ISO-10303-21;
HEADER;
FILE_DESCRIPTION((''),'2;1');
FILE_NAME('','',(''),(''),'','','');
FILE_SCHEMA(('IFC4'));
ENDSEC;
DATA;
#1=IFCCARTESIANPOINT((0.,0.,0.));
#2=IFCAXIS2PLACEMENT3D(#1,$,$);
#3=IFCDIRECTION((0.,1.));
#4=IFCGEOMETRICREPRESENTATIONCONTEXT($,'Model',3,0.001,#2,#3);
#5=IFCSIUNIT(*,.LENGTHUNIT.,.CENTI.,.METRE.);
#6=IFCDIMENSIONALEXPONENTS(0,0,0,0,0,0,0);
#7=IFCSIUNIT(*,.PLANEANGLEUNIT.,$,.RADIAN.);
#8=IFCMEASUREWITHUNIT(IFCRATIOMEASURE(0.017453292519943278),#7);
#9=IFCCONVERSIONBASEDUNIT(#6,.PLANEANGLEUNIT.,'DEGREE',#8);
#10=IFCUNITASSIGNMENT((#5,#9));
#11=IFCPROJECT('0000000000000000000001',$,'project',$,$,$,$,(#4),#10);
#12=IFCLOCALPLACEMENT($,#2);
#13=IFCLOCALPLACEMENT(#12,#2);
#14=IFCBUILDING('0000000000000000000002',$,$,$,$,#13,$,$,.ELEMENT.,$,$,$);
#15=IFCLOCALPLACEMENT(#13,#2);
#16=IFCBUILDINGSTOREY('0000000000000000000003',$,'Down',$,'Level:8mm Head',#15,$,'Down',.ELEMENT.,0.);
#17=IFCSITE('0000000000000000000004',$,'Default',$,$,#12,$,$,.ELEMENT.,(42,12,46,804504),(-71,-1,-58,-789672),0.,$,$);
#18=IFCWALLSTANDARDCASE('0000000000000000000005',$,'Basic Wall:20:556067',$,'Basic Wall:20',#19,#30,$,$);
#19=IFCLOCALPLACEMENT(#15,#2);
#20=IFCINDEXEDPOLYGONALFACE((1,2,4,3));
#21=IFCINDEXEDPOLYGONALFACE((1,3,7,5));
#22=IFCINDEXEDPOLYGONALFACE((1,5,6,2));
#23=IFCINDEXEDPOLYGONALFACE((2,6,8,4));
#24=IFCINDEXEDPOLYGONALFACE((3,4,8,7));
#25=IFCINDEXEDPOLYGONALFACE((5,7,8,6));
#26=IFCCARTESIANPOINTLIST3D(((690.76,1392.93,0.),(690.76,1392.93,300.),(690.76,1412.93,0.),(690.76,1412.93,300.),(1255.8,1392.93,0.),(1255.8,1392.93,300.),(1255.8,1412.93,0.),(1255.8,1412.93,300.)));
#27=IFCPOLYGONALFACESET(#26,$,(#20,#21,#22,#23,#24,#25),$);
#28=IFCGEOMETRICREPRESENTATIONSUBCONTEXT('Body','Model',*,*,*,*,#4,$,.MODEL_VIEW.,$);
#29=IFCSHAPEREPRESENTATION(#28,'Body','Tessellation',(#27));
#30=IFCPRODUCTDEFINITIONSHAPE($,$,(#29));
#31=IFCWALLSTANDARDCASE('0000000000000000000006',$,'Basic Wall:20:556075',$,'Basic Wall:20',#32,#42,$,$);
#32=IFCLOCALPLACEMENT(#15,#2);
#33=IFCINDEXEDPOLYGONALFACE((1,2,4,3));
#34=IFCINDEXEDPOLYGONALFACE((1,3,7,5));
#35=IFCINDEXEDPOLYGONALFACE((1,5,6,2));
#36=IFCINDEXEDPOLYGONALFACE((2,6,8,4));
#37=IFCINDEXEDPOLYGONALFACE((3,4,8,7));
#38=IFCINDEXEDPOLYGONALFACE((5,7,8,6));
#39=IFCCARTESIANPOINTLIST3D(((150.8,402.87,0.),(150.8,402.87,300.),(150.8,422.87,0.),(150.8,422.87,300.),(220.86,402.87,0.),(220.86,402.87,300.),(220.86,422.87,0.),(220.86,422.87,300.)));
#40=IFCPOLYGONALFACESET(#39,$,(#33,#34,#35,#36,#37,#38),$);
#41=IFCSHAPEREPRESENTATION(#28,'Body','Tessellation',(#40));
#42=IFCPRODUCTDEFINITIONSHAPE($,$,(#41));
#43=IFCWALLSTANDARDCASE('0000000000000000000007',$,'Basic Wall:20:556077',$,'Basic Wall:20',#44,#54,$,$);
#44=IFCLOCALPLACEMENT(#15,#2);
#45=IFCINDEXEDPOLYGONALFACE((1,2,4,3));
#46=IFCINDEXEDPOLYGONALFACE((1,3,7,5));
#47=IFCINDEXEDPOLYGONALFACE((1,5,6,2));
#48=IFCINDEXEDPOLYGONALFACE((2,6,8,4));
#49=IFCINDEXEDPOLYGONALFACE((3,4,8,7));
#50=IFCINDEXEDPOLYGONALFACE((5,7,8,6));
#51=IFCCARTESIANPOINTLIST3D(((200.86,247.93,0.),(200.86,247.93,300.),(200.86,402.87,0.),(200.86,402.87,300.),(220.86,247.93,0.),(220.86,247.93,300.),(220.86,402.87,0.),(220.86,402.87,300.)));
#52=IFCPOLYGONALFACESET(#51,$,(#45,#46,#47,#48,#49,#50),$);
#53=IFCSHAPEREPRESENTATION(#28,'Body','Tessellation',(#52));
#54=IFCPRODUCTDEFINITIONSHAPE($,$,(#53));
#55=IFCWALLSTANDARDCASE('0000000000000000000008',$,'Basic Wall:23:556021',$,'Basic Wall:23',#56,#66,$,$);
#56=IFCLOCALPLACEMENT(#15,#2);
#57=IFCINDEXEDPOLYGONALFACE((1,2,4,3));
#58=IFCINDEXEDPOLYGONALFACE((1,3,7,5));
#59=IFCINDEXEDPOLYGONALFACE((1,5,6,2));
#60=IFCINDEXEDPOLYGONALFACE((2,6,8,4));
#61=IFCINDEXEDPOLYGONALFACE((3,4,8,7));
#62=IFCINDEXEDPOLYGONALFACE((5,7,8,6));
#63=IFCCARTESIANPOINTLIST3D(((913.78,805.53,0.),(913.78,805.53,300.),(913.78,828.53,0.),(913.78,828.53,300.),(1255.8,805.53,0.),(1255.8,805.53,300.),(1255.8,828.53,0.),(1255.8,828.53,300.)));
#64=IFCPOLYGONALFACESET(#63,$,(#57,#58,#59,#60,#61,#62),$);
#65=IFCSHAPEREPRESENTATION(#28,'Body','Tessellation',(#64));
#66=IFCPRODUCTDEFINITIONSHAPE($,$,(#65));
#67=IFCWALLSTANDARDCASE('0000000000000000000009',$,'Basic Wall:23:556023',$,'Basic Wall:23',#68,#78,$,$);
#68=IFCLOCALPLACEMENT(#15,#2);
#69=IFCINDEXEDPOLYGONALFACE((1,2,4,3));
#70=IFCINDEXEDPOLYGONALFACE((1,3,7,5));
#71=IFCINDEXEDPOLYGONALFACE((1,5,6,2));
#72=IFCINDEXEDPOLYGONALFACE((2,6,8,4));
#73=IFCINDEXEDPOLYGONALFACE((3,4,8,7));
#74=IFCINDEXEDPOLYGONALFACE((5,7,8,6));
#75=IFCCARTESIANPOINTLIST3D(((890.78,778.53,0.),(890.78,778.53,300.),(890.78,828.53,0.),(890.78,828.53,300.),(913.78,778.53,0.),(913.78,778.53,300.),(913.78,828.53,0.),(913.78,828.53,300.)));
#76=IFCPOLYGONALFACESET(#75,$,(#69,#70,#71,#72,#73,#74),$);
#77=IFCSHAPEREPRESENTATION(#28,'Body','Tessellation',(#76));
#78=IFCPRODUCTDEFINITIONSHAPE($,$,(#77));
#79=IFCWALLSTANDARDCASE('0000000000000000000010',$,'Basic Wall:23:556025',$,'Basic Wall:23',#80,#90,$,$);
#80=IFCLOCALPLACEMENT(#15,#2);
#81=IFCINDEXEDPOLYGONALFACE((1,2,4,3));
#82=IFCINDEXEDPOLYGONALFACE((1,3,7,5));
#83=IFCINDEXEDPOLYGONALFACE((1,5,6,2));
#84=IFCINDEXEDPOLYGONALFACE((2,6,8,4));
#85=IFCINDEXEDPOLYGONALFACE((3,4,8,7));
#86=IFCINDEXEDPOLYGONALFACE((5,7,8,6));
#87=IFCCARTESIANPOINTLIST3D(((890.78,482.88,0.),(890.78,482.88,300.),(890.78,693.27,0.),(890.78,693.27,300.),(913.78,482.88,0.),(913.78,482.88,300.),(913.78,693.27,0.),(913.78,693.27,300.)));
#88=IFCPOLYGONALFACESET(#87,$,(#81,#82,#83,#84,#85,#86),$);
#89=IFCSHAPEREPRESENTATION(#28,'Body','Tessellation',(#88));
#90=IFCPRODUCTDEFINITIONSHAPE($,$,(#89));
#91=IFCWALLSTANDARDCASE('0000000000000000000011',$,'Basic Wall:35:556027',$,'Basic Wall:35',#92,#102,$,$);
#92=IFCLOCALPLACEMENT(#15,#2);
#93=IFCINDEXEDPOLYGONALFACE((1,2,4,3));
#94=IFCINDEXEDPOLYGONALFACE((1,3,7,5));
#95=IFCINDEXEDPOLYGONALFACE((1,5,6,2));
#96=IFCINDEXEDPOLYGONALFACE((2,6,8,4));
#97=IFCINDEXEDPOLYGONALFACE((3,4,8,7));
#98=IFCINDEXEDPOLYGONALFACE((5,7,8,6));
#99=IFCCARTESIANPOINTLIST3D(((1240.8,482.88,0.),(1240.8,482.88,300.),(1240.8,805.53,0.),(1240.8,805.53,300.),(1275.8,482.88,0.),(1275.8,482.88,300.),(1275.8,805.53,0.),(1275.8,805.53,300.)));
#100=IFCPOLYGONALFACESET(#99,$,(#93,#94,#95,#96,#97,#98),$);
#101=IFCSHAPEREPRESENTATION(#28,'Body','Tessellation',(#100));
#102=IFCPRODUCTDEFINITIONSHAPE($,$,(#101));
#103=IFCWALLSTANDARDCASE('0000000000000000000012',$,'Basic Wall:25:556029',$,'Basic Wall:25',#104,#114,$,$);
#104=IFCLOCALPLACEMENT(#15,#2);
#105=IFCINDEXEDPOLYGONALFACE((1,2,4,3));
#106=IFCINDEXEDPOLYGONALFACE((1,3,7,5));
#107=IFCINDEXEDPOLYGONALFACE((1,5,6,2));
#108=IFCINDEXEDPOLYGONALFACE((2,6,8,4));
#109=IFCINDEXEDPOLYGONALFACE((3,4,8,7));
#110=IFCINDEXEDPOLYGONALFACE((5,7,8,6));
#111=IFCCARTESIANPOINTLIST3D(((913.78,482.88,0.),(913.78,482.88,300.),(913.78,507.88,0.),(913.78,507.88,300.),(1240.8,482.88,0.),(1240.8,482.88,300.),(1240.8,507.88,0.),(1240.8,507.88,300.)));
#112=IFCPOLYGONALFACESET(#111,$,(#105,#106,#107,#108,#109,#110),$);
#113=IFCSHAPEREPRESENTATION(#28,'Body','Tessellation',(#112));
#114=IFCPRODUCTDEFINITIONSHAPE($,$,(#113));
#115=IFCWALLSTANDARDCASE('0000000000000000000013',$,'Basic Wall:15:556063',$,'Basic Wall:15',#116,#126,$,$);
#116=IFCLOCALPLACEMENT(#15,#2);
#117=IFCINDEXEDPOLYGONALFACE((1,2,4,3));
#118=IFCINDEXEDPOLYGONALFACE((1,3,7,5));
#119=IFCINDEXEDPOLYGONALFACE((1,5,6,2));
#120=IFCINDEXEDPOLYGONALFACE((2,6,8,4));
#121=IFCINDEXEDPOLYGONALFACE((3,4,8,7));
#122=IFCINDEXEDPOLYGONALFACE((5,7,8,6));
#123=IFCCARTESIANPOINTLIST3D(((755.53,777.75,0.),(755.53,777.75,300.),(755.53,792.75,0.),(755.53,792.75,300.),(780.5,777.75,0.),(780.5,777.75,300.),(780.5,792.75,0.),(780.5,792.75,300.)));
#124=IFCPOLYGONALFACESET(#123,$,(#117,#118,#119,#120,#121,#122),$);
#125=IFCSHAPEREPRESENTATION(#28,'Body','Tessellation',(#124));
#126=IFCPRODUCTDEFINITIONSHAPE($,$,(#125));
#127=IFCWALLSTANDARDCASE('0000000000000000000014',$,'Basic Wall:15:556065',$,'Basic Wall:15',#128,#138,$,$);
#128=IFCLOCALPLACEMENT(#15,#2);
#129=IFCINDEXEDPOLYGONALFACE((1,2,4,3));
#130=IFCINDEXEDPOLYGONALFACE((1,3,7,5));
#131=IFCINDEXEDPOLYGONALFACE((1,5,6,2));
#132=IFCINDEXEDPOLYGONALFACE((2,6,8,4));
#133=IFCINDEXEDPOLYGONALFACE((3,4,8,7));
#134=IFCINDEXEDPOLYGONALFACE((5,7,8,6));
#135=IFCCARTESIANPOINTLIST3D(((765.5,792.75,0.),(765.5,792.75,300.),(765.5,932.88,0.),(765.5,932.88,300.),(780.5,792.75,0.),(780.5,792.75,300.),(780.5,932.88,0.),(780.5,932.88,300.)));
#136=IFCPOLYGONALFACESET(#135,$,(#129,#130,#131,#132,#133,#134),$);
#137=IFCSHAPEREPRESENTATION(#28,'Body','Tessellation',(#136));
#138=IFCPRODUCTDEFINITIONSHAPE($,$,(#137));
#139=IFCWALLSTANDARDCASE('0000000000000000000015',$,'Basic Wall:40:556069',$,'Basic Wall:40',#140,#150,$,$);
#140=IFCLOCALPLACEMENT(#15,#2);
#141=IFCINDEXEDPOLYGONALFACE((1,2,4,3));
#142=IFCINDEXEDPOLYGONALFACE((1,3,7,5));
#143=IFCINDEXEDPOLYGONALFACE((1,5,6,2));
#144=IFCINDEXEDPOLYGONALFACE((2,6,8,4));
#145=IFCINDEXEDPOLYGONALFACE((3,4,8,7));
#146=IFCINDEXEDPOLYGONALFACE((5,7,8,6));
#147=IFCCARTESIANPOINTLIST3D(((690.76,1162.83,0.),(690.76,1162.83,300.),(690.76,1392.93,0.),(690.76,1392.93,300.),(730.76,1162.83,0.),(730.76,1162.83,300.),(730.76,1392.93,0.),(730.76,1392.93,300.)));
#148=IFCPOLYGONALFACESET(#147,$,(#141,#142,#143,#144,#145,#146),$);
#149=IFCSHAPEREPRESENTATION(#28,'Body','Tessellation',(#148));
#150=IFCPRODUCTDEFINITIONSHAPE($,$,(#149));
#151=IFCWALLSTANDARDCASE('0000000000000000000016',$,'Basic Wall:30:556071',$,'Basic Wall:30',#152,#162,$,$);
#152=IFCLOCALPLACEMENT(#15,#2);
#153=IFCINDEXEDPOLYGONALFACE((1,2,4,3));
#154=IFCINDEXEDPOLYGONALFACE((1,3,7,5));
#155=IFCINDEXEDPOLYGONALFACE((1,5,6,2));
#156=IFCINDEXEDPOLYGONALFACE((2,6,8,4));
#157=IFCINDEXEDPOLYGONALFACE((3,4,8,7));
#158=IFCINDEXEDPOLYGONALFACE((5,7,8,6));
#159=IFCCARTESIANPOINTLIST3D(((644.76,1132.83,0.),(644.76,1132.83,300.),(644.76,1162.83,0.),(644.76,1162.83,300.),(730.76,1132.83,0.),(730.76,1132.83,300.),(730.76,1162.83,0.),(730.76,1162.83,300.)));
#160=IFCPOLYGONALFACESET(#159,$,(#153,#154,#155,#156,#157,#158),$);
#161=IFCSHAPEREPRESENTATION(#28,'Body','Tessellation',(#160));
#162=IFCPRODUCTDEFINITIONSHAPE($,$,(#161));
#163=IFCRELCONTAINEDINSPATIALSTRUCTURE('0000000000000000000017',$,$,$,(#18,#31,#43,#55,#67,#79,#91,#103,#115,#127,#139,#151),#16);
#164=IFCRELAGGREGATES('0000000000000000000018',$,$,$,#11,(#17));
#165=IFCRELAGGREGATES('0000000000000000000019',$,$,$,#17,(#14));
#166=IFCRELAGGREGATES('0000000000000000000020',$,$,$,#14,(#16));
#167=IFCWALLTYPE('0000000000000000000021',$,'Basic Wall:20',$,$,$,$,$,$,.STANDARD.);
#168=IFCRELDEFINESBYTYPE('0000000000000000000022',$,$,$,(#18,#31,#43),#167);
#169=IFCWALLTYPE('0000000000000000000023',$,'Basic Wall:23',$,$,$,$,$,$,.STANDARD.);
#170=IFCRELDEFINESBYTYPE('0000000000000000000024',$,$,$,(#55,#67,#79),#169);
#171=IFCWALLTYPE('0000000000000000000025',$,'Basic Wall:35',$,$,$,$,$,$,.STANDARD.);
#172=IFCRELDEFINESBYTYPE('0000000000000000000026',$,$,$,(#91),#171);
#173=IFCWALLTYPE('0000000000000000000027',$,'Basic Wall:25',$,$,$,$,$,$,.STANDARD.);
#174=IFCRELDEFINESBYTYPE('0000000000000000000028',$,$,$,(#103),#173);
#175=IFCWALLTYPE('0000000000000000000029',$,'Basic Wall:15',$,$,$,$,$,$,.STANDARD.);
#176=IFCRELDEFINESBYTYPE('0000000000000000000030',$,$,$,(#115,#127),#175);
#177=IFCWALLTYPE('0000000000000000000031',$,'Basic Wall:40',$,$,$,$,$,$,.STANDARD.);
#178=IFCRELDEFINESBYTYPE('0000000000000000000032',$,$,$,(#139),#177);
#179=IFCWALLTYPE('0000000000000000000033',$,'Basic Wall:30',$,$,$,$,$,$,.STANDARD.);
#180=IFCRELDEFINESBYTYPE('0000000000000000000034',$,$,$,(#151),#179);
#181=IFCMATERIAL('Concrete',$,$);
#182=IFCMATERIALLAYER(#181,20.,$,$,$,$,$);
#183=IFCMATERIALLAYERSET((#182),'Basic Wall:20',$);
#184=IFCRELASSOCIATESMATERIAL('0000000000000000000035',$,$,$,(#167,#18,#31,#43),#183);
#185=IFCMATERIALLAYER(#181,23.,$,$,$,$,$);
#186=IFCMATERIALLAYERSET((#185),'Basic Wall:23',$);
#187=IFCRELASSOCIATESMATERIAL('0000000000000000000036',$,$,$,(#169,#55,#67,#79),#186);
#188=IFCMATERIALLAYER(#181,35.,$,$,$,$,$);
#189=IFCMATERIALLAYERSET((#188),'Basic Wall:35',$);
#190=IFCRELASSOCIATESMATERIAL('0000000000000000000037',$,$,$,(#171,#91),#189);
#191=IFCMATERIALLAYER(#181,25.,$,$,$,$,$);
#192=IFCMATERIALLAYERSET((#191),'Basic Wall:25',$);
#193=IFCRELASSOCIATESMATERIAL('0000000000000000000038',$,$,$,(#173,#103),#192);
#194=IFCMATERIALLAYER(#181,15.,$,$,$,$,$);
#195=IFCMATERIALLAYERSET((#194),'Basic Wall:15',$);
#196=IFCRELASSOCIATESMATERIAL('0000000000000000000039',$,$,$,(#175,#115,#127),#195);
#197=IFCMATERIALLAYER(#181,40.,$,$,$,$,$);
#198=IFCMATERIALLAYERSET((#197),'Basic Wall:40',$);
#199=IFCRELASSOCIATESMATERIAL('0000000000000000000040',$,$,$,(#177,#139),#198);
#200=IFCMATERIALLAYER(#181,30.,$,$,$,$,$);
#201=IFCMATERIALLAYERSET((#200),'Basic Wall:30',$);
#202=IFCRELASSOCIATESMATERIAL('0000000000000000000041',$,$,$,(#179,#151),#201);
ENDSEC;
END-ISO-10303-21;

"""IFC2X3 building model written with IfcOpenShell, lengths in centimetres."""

from ifc_helpers import new_model, entity, si_unit, converted_unit, direction, frame, frame_2d, origin, place, context, subcontext, project, spatial, rectangle, extrude, material, layer, layer_set, layer_usage, type_object, element, save


model = new_model("IFC2X3")

# Units and contexts
model_context = context("Model", 3, precision=0.001, world=origin(), true_north=direction((0.0, 1.0)))
body_context = subcontext(model_context, "Body", "Model", "MODEL_VIEW")
ifc_project = project(units=[si_unit("LENGTHUNIT", "METRE", prefix="CENTI"), converted_unit("PLANEANGLEUNIT", "DEGREE", entity("IfcRatioMeasure", 0.017453292519943278), si_unit("PLANEANGLEUNIT", "RADIAN"), dimensions=[0, 0, 0, 0, 0, 0, 0])], contexts=[model_context])

# Site, building, storey
site_placement = place(None, origin())
site = spatial("IfcSite", under=ifc_project, at=site_placement, Name="Default", CompositionType="ELEMENT", RefLatitude=(42, 12, 46, 804504), RefLongitude=(-71, -1, -58, -789672), RefElevation=0.0)
building_placement = place(site_placement, origin())
building = spatial("IfcBuilding", under=site, at=building_placement, CompositionType="ELEMENT")
storey_placement = place(building_placement, origin())
storey = spatial("IfcBuildingStorey", under=building, at=storey_placement, Name="Down", ObjectType="Level:8mm Head", LongName="Down", CompositionType="ELEMENT", Elevation=0.0)

# Walls
ifc_material = material(Name="Concrete")
ifc_layer_1 = layer(ifc_material, 20.0)
ifc_layer_set_1 = layer_set([ifc_layer_1], Name="Basic Wall:20")
wall_type_1 = type_object("IfcWallType", Name="Basic Wall:20", PredefinedType="STANDARD", material=ifc_layer_set_1)
ifc_layer_usage_1 = layer_usage(ifc_layer_set_1, "AXIS2", "POSITIVE", -10.0)
wall_1_placement = place(storey_placement, frame((1255.8, 1402.93, 0.0), z_axis=(0.0, 0.0, 1.0), x_axis=(-1.0, 0.0, 0.0)))
element("IfcWallStandardCase", 1, at=wall_1_placement, inside=storey, type_object=wall_type_1, material=ifc_layer_usage_1, Name="Basic Wall:20:556067", ObjectType="Basic Wall:20", context=body_context, shape_type="SweptSolid", body=[
    extrude(rectangle(XDim=565.04, YDim=20.0, at=frame_2d((282.52, 0.0), x_axis=(-1.0, 0.0))), origin(), (0.0, 0.0, 1.0), 300.0),
])
ifc_layer_usage_2 = layer_usage(ifc_layer_set_1, "AXIS2", "POSITIVE", -10.0)
wall_2_placement = place(storey_placement, frame((150.8, 412.87, 0.0)))
element("IfcWallStandardCase", 2, at=wall_2_placement, inside=storey, type_object=wall_type_1, material=ifc_layer_usage_2, Name="Basic Wall:20:556075", ObjectType="Basic Wall:20", context=body_context, shape_type="SweptSolid", body=[
    extrude(rectangle(XDim=70.06, YDim=20.0, at=frame_2d((35.03, 0.0), x_axis=(-1.0, 0.0))), origin(), (0.0, 0.0, 1.0), 300.0),
])
ifc_layer_usage_3 = layer_usage(ifc_layer_set_1, "AXIS2", "NEGATIVE", 10.0)
wall_3_placement = place(storey_placement, frame((210.86, 402.87, 0.0), z_axis=(0.0, 0.0, 1.0), x_axis=(0.0, -1.0, 0.0)))
element("IfcWallStandardCase", 3, at=wall_3_placement, inside=storey, type_object=wall_type_1, material=ifc_layer_usage_3, Name="Basic Wall:20:556077", ObjectType="Basic Wall:20", context=body_context, shape_type="SweptSolid", body=[
    extrude(rectangle(XDim=154.94, YDim=20.0, at=frame_2d((77.47, 0.0), x_axis=(-1.0, 0.0))), origin(), (0.0, 0.0, 1.0), 300.0),
])
ifc_layer_2 = layer(ifc_material, 23.0)
ifc_layer_set_2 = layer_set([ifc_layer_2], Name="Basic Wall:23")
ifc_layer_usage_4 = layer_usage(ifc_layer_set_2, "AXIS2", "POSITIVE", -11.5)
wall_type_2 = type_object("IfcWallType", Name="Basic Wall:23", PredefinedType="STANDARD", material=ifc_layer_set_2)
wall_4_placement = place(storey_placement, frame((1255.8, 817.03, 0.0), z_axis=(0.0, 0.0, 1.0), x_axis=(-1.0, 0.0, 0.0)))
element("IfcWallStandardCase", 4, at=wall_4_placement, inside=storey, type_object=wall_type_2, material=ifc_layer_usage_4, Name="Basic Wall:23:556021", ObjectType="Basic Wall:23", context=body_context, shape_type="SweptSolid", body=[
    extrude(rectangle(XDim=342.02, YDim=23.0, at=frame_2d((171.01, 0.0), x_axis=(-1.0, 0.0))), origin(), (0.0, 0.0, 1.0), 300.0),
])
ifc_layer_usage_5 = layer_usage(ifc_layer_set_2, "AXIS2", "POSITIVE", -11.5)
wall_5_placement = place(storey_placement, frame((902.28, 828.53, 0.0), z_axis=(0.0, 0.0, 1.0), x_axis=(0.0, -1.0, 0.0)))
element("IfcWallStandardCase", 5, at=wall_5_placement, inside=storey, type_object=wall_type_2, material=ifc_layer_usage_5, Name="Basic Wall:23:556023", ObjectType="Basic Wall:23", context=body_context, shape_type="SweptSolid", body=[
    extrude(rectangle(XDim=50.0, YDim=23.0, at=frame_2d((25.0, 0.0), x_axis=(-1.0, 0.0))), origin(), (0.0, 0.0, 1.0), 300.0),
])
ifc_layer_usage_6 = layer_usage(ifc_layer_set_2, "AXIS2", "POSITIVE", -11.5)
wall_6_placement = place(storey_placement, frame((902.28, 693.27, 0.0), z_axis=(0.0, 0.0, 1.0), x_axis=(0.0, -1.0, 0.0)))
element("IfcWallStandardCase", 6, at=wall_6_placement, inside=storey, type_object=wall_type_2, material=ifc_layer_usage_6, Name="Basic Wall:23:556025", ObjectType="Basic Wall:23", context=body_context, shape_type="SweptSolid", body=[
    extrude(rectangle(XDim=210.4, YDim=23.0, at=frame_2d((105.2, 0.0), x_axis=(-1.0, 0.0))), origin(), (0.0, 0.0, 1.0), 300.0),
])
ifc_layer_3 = layer(ifc_material, 35.0)
ifc_layer_set_3 = layer_set([ifc_layer_3], Name="Basic Wall:35")
ifc_layer_usage_7 = layer_usage(ifc_layer_set_3, "AXIS2", "NEGATIVE", 17.5)
wall_type_3 = type_object("IfcWallType", Name="Basic Wall:35", PredefinedType="STANDARD", material=ifc_layer_set_3)
wall_7_placement = place(storey_placement, frame((1258.3, 805.53, 0.0), z_axis=(0.0, 0.0, 1.0), x_axis=(0.0, -1.0, 0.0)))
element("IfcWallStandardCase", 7, at=wall_7_placement, inside=storey, type_object=wall_type_3, material=ifc_layer_usage_7, Name="Basic Wall:35:556027", ObjectType="Basic Wall:35", context=body_context, shape_type="SweptSolid", body=[
    extrude(rectangle(XDim=322.65, YDim=35.0, at=frame_2d((161.32, 0.0), x_axis=(-1.0, 0.0))), origin(), (0.0, 0.0, 1.0), 300.0),
])
ifc_layer_4 = layer(ifc_material, 25.0)
ifc_layer_set_4 = layer_set([ifc_layer_4], Name="Basic Wall:25")
ifc_layer_usage_8 = layer_usage(ifc_layer_set_4, "AXIS2", "NEGATIVE", 12.5)
wall_type_4 = type_object("IfcWallType", Name="Basic Wall:25", PredefinedType="STANDARD", material=ifc_layer_set_4)
wall_8_placement = place(storey_placement, frame((1240.8, 495.38, 0.0), z_axis=(0.0, 0.0, 1.0), x_axis=(-1.0, 0.0, 0.0)))
element("IfcWallStandardCase", 8, at=wall_8_placement, inside=storey, type_object=wall_type_4, material=ifc_layer_usage_8, Name="Basic Wall:25:556029", ObjectType="Basic Wall:25", context=body_context, shape_type="SweptSolid", body=[
    extrude(rectangle(XDim=327.02, YDim=25.0, at=frame_2d((163.51, 0.0), x_axis=(-1.0, 0.0))), origin(), (0.0, 0.0, 1.0), 300.0),
])
ifc_layer_5 = layer(ifc_material, 15.0)
ifc_layer_set_5 = layer_set([ifc_layer_5], Name="Basic Wall:15")
ifc_layer_usage_9 = layer_usage(ifc_layer_set_5, "AXIS2", "NEGATIVE", 7.5)
wall_type_5 = type_object("IfcWallType", Name="Basic Wall:15", PredefinedType="STANDARD", material=ifc_layer_set_5)
wall_9_placement = place(storey_placement, frame((755.53, 785.25, 0.0)))
element("IfcWallStandardCase", 9, at=wall_9_placement, inside=storey, type_object=wall_type_5, material=ifc_layer_usage_9, Name="Basic Wall:15:556063", ObjectType="Basic Wall:15", context=body_context, shape_type="SweptSolid", body=[
    extrude(rectangle(XDim=24.98, YDim=15.0, at=frame_2d((12.49, 0.0), x_axis=(-1.0, 0.0))), origin(), (0.0, 0.0, 1.0), 300.0),
])
ifc_layer_usage_10 = layer_usage(ifc_layer_set_5, "AXIS2", "POSITIVE", -7.5)
wall_10_placement = place(storey_placement, frame((773.0, 792.75, 0.0), z_axis=(0.0, 0.0, 1.0), x_axis=(0.0, 1.0, 0.0)))
element("IfcWallStandardCase", 10, at=wall_10_placement, inside=storey, type_object=wall_type_5, material=ifc_layer_usage_10, Name="Basic Wall:15:556065", ObjectType="Basic Wall:15", context=body_context, shape_type="SweptSolid", body=[
    extrude(rectangle(XDim=140.12, YDim=15.0, at=frame_2d((70.06, 0.0), x_axis=(-1.0, 0.0))), origin(), (0.0, 0.0, 1.0), 300.0),
])
ifc_layer_6 = layer(ifc_material, 40.0)
ifc_layer_set_6 = layer_set([ifc_layer_6], Name="Basic Wall:40")
ifc_layer_usage_11 = layer_usage(ifc_layer_set_6, "AXIS2", "POSITIVE", -20.0)
wall_type_6 = type_object("IfcWallType", Name="Basic Wall:40", PredefinedType="STANDARD", material=ifc_layer_set_6)
wall_11_placement = place(storey_placement, frame((710.76, 1392.93, 0.0), z_axis=(0.0, 0.0, 1.0), x_axis=(0.0, -1.0, 0.0)))
element("IfcWallStandardCase", 11, at=wall_11_placement, inside=storey, type_object=wall_type_6, material=ifc_layer_usage_11, Name="Basic Wall:40:556069", ObjectType="Basic Wall:40", context=body_context, shape_type="SweptSolid", body=[
    extrude(rectangle(XDim=230.11, YDim=40.0, at=frame_2d((115.05, 0.0), x_axis=(-1.0, 0.0))), origin(), (0.0, 0.0, 1.0), 300.0),
])
ifc_layer_7 = layer(ifc_material, 30.0)
ifc_layer_set_7 = layer_set([ifc_layer_7], Name="Basic Wall:30")
ifc_layer_usage_12 = layer_usage(ifc_layer_set_7, "AXIS2", "NEGATIVE", 15.0)
wall_type_7 = type_object("IfcWallType", Name="Basic Wall:30", PredefinedType="STANDARD", material=ifc_layer_set_7)
wall_12_placement = place(storey_placement, frame((730.76, 1147.83, 0.0), z_axis=(0.0, 0.0, 1.0), x_axis=(-1.0, 0.0, 0.0)))
element("IfcWallStandardCase", 12, at=wall_12_placement, inside=storey, type_object=wall_type_7, material=ifc_layer_usage_12, Name="Basic Wall:30:556071", ObjectType="Basic Wall:30", context=body_context, shape_type="SweptSolid", body=[
    extrude(rectangle(XDim=86.0, YDim=30.0, at=frame_2d((43.0, 0.0), x_axis=(-1.0, 0.0))), origin(), (0.0, 0.0, 1.0), 300.0),
])

save(model, "model.ifc")
